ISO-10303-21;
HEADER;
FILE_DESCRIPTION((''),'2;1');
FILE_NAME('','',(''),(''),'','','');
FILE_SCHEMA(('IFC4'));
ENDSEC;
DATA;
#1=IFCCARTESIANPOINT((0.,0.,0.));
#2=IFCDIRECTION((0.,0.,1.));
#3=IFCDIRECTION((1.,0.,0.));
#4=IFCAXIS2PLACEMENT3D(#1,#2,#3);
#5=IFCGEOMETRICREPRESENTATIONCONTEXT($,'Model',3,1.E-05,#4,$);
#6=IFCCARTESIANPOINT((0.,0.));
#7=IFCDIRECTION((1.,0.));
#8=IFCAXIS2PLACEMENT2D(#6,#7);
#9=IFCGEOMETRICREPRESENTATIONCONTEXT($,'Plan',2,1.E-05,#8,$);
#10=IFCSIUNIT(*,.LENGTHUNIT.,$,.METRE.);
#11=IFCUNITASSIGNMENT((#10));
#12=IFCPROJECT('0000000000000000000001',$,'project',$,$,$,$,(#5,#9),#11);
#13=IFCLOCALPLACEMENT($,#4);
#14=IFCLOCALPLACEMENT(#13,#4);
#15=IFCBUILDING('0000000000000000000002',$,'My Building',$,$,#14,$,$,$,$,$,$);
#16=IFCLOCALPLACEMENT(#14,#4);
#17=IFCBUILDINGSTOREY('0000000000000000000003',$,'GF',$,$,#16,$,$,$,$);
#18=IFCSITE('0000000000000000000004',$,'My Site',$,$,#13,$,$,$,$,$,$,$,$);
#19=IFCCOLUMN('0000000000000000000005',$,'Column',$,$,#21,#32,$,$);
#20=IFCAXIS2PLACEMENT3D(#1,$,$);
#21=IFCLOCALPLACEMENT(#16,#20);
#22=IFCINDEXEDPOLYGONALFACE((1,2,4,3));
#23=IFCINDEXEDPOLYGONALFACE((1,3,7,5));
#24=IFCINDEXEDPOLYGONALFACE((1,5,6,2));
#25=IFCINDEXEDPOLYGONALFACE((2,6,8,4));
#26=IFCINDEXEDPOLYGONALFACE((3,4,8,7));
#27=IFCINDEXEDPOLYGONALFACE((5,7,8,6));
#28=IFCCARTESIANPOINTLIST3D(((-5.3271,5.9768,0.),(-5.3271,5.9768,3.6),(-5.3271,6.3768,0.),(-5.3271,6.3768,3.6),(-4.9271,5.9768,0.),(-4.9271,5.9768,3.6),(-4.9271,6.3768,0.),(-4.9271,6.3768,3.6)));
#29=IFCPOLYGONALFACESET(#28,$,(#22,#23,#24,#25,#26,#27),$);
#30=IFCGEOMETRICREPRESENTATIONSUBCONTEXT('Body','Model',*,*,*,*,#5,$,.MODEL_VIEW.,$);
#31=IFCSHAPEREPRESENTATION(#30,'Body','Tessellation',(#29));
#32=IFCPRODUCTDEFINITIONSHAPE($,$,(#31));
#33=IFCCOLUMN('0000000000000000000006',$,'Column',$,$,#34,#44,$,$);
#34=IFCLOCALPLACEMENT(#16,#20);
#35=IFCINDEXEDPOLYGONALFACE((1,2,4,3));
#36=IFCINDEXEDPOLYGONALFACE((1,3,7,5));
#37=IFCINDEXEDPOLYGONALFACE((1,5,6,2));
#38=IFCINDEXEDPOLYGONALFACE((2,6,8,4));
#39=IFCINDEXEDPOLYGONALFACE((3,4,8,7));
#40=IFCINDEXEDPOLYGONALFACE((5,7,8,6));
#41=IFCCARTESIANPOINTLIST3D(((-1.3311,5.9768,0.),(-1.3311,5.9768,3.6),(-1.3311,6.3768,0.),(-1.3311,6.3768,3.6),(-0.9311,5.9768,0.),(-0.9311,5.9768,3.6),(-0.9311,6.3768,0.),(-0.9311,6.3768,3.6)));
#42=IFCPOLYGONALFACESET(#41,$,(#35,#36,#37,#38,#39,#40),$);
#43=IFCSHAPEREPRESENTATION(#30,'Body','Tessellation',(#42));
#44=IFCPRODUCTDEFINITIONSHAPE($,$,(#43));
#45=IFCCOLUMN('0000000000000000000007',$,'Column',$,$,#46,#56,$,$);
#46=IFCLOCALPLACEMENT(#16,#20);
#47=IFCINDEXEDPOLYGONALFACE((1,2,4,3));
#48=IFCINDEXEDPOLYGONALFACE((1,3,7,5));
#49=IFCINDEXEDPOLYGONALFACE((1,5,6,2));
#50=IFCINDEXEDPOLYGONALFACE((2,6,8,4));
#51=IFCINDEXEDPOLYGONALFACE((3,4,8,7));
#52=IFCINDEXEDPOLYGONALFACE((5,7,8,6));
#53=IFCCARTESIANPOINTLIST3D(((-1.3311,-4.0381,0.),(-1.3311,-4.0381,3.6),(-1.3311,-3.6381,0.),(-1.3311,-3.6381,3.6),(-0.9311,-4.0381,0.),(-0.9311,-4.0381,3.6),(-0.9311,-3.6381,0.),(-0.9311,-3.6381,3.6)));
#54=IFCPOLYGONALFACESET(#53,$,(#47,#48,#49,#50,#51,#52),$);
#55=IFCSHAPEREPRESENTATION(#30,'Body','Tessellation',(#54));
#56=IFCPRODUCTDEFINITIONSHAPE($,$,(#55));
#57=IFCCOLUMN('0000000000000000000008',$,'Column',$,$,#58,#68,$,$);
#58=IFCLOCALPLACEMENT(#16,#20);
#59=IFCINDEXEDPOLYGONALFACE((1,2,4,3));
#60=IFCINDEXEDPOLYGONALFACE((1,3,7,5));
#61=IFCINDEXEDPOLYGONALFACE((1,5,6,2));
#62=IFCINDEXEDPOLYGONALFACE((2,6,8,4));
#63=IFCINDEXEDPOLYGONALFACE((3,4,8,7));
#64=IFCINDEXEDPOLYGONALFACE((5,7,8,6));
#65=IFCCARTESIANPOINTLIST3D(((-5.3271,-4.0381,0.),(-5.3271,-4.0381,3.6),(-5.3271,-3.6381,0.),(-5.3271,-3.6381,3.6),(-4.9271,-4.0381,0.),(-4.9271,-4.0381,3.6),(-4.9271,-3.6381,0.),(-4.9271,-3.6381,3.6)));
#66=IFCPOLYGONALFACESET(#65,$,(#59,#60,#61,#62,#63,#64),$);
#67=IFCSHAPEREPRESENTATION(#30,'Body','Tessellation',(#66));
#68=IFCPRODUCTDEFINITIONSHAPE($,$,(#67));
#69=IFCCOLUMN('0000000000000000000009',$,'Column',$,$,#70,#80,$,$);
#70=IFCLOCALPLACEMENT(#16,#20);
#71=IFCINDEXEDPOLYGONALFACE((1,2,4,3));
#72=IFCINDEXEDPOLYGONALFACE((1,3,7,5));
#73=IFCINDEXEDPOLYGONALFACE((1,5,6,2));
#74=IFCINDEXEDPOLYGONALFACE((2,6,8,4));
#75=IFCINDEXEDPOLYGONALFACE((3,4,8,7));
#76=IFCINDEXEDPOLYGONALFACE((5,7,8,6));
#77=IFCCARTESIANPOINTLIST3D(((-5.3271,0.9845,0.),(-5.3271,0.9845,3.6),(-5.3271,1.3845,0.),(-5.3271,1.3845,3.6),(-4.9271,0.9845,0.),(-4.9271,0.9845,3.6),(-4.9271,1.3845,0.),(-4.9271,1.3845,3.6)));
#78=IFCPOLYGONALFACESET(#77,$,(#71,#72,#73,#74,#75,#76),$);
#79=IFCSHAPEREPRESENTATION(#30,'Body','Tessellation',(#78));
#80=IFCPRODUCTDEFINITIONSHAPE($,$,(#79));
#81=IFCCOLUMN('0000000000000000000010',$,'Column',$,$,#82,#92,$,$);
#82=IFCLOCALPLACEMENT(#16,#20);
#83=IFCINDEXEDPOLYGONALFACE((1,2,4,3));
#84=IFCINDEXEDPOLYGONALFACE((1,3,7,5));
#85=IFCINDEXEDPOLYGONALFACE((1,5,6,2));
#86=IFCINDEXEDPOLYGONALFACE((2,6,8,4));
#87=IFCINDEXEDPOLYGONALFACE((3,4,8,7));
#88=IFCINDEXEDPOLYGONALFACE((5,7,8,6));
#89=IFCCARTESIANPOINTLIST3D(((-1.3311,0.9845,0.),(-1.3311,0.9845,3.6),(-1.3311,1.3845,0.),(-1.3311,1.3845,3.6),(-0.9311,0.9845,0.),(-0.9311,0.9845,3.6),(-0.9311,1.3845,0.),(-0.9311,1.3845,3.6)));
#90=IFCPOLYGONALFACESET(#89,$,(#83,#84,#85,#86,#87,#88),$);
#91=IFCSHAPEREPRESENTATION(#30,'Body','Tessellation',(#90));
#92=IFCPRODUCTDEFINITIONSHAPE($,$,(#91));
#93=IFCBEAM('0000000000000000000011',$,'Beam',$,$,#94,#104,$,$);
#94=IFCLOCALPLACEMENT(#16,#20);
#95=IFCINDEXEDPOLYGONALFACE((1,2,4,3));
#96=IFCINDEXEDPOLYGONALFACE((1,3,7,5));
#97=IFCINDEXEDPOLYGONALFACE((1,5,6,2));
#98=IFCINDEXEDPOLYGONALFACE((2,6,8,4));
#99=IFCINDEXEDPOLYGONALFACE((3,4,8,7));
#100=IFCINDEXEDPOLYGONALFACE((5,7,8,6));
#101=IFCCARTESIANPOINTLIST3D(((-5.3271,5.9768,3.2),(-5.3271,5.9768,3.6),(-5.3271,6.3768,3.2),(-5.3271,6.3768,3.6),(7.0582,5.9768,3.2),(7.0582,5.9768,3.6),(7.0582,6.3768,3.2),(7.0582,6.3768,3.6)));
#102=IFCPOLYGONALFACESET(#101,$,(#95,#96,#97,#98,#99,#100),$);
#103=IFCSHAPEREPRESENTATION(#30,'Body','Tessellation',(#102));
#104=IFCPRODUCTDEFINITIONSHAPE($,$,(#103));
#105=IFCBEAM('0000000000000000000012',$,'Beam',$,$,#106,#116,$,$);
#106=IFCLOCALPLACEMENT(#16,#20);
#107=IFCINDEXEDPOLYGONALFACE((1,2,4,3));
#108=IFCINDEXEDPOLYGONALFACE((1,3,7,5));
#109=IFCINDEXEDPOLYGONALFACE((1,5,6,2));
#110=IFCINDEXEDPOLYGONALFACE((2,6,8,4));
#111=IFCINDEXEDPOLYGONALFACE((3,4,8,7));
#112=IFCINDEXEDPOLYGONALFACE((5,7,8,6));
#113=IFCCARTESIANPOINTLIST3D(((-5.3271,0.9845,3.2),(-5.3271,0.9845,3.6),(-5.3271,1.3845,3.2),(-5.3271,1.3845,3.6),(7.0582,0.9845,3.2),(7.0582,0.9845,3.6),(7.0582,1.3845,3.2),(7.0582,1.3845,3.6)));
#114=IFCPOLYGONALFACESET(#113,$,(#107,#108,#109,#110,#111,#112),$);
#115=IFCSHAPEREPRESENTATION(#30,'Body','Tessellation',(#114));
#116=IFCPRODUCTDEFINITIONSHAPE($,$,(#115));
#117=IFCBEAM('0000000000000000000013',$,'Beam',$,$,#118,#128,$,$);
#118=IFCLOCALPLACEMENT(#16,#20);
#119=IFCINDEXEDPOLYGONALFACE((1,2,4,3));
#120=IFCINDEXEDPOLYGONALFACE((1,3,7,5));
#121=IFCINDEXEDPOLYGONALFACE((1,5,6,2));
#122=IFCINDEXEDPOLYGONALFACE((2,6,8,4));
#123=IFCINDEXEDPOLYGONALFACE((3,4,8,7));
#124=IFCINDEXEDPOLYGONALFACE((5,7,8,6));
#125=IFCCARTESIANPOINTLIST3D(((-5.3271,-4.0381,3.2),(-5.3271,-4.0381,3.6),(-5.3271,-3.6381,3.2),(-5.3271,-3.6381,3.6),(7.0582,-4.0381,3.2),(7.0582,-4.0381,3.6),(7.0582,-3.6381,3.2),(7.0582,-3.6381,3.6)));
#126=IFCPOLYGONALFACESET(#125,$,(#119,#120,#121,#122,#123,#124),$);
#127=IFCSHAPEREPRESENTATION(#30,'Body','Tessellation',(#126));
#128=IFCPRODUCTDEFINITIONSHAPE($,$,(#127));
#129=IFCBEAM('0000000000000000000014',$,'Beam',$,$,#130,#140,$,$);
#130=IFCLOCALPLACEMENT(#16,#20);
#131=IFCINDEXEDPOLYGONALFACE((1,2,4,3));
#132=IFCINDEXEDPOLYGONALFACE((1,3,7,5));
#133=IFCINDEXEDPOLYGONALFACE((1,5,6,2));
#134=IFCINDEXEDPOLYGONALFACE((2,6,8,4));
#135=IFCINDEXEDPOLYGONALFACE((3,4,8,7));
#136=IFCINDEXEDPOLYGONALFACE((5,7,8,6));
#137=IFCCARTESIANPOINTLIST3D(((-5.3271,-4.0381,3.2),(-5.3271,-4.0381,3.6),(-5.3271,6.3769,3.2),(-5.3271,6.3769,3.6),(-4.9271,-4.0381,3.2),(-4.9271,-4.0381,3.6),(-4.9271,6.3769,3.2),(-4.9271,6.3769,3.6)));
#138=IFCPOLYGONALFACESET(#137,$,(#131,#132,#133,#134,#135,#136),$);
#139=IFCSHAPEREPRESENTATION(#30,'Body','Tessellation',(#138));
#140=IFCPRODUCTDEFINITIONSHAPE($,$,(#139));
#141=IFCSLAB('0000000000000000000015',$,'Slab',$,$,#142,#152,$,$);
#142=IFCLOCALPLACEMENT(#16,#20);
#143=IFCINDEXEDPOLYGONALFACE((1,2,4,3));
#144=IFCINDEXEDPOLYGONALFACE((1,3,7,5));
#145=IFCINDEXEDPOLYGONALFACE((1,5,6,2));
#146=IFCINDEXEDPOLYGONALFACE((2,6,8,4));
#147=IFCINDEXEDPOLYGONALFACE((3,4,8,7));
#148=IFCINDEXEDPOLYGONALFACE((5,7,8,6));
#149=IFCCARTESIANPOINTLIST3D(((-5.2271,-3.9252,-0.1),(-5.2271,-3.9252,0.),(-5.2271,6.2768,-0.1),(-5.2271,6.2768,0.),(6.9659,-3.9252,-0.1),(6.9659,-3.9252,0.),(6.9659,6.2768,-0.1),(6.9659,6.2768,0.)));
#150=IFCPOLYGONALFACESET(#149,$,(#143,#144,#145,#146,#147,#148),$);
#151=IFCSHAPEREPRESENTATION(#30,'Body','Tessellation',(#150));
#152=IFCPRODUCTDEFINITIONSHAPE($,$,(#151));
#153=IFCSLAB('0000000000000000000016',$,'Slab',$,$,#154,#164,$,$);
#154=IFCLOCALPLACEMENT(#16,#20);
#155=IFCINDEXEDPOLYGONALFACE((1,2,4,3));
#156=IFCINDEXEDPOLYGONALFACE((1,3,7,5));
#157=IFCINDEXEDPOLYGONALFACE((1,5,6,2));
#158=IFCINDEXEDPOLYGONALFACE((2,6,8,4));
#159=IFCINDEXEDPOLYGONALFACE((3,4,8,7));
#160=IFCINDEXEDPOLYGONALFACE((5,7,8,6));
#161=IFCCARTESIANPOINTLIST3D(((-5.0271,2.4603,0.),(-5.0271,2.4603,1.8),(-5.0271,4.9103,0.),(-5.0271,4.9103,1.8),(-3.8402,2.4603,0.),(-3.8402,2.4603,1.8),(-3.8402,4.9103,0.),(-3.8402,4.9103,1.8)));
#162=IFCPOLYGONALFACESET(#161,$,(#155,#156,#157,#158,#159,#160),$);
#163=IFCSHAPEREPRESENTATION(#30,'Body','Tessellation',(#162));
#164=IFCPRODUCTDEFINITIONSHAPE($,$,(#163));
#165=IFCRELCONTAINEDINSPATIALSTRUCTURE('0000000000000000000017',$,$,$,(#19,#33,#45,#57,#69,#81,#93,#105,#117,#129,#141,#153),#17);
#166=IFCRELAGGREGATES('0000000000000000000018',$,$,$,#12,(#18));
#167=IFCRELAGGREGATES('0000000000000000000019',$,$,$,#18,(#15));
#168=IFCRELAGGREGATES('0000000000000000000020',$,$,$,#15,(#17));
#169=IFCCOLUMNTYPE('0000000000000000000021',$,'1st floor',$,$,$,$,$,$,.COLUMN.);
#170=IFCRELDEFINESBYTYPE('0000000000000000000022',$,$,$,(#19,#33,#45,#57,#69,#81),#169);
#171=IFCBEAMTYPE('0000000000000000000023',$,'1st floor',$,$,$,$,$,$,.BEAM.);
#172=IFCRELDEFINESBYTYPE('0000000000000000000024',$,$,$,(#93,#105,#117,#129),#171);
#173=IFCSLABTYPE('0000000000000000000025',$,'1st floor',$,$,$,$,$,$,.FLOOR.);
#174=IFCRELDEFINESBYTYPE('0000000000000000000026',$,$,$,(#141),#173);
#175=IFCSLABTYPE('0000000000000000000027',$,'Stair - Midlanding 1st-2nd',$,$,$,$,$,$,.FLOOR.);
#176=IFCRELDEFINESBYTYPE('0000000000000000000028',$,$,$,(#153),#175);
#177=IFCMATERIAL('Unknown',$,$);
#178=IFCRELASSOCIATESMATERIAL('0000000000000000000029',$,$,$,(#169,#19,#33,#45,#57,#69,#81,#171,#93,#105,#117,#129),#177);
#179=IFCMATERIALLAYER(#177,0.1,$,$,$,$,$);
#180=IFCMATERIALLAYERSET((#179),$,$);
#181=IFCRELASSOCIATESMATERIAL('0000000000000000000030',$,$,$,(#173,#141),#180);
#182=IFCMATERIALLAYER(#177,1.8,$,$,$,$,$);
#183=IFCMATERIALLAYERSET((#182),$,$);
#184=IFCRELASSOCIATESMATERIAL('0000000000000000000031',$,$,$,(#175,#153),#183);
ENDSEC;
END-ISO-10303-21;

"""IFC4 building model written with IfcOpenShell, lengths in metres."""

from ifc_helpers import new_model, si_unit, frame, origin_with_axes, origin_2d_with_axis, place, context, subcontext, project, spatial, indexed_curve, rectangle, outline, extrude, material, layer, layer_set, layer_usage, material_profile, profile_set, profile_usage, type_object, element, save


model = new_model("IFC4")

# Units and contexts
model_context = context("Model", 3, precision=1e-05, world=origin_with_axes())
plan_context = context("Plan", 2, precision=1e-05, world=origin_2d_with_axis())
body_context_1 = subcontext(model_context, "Body", "Model", "MODEL_VIEW")
ifc_project = project(units=[si_unit("LENGTHUNIT", "METRE")], contexts=[model_context, plan_context])

# Site, building, storey
site_placement = place(None, origin_with_axes())
site = spatial("IfcSite", under=ifc_project, at=site_placement, Name="My Site")
building_placement = place(site_placement, origin_with_axes())
building = spatial("IfcBuilding", under=site, at=building_placement, Name="My Building")
storey_placement = place(building_placement, origin_with_axes())
storey = spatial("IfcBuildingStorey", under=building, at=storey_placement, Name="GF")

# Columns
ifc_material = material(Name="Unknown")
ifc_material_profile_1 = material_profile(ifc_material, rectangle(XDim=0.4, YDim=0.4))
ifc_profile_set_1 = profile_set([ifc_material_profile_1])
ifc_profile_usage_1 = profile_usage(ifc_profile_set_1, cardinal=5)
column_type = type_object("IfcColumnType", Name="1st floor", PredefinedType="COLUMN", material=ifc_profile_set_1)
column_1_placement = place(storey_placement, frame((-5.1271, 6.1768, 0.0), z_axis=(0.0, 0.0, 1.0), x_axis=(1.0, 0.0, 0.0)))
element("IfcColumn", 1, at=column_1_placement, inside=storey, type_object=column_type, material=ifc_profile_usage_1, Name="Column", context=body_context_1, shape_type="SweptSolid", body=[
    extrude(rectangle(XDim=0.4, YDim=0.4), origin_with_axes(), (0.0, 0.0, 1.0), 3.6),
])
ifc_profile_usage_2 = profile_usage(ifc_profile_set_1, cardinal=5)
column_2_placement = place(storey_placement, frame((-1.1311, 6.1768, 0.0), z_axis=(0.0, 0.0, 1.0), x_axis=(1.0, 0.0, 0.0)))
element("IfcColumn", 2, at=column_2_placement, inside=storey, type_object=column_type, material=ifc_profile_usage_2, Name="Column", context=body_context_1, shape_type="SweptSolid", body=[
    extrude(rectangle(XDim=0.4, YDim=0.4), origin_with_axes(), (0.0, 0.0, 1.0), 3.6),
])
ifc_profile_usage_3 = profile_usage(ifc_profile_set_1, cardinal=5)
column_3_placement = place(storey_placement, frame((-1.1311, -3.8381, 0.0), z_axis=(0.0, 0.0, 1.0), x_axis=(1.0, 0.0, 0.0)))
element("IfcColumn", 3, at=column_3_placement, inside=storey, type_object=column_type, material=ifc_profile_usage_3, Name="Column", context=body_context_1, shape_type="SweptSolid", body=[
    extrude(rectangle(XDim=0.4, YDim=0.4), origin_with_axes(), (0.0, 0.0, 1.0), 3.6),
])
ifc_profile_usage_4 = profile_usage(ifc_profile_set_1, cardinal=5)
column_4_placement = place(storey_placement, frame((-5.1271, -3.8381, 0.0), z_axis=(0.0, 0.0, 1.0), x_axis=(1.0, 0.0, 0.0)))
element("IfcColumn", 4, at=column_4_placement, inside=storey, type_object=column_type, material=ifc_profile_usage_4, Name="Column", context=body_context_1, shape_type="SweptSolid", body=[
    extrude(rectangle(XDim=0.4, YDim=0.4), origin_with_axes(), (0.0, 0.0, 1.0), 3.6),
])
ifc_profile_usage_5 = profile_usage(ifc_profile_set_1, cardinal=5)
column_5_placement = place(storey_placement, frame((-5.1271, 1.1845, 0.0), z_axis=(0.0, 0.0, 1.0), x_axis=(1.0, 0.0, 0.0)))
element("IfcColumn", 5, at=column_5_placement, inside=storey, type_object=column_type, material=ifc_profile_usage_5, Name="Column", context=body_context_1, shape_type="SweptSolid", body=[
    extrude(rectangle(XDim=0.4, YDim=0.4), origin_with_axes(), (0.0, 0.0, 1.0), 3.6),
])
ifc_profile_usage_6 = profile_usage(ifc_profile_set_1, cardinal=5)
column_6_placement = place(storey_placement, frame((-1.1311, 1.1845, 0.0), z_axis=(0.0, 0.0, 1.0), x_axis=(1.0, 0.0, 0.0)))
element("IfcColumn", 6, at=column_6_placement, inside=storey, type_object=column_type, material=ifc_profile_usage_6, Name="Column", context=body_context_1, shape_type="SweptSolid", body=[
    extrude(rectangle(XDim=0.4, YDim=0.4), origin_with_axes(), (0.0, 0.0, 1.0), 3.6),
])

# Beams
ifc_material_profile_2 = material_profile(ifc_material, rectangle(XDim=0.4, YDim=0.4))
ifc_profile_set_2 = profile_set([ifc_material_profile_2])
ifc_profile_usage_7 = profile_usage(ifc_profile_set_2, cardinal=5)
beam_type = type_object("IfcBeamType", Name="1st floor", PredefinedType="BEAM", material=ifc_profile_set_2)
beam_1_placement = place(storey_placement, frame((-5.3271, 6.1768, 3.4), z_axis=(1.0, 0.0, 0.0), x_axis=(0.0, 1.0, 0.0)))
element("IfcBeam", 7, at=beam_1_placement, inside=storey, type_object=beam_type, material=ifc_profile_usage_7, Name="Beam", context=body_context_1, shape_type="SweptSolid", body=[
    extrude(rectangle(XDim=0.4, YDim=0.4), origin_with_axes(), (0.0, 0.0, 1.0), 12.3854),
])
ifc_profile_usage_8 = profile_usage(ifc_profile_set_2, cardinal=5)
beam_2_placement = place(storey_placement, frame((-5.3271, 1.1845, 3.4), z_axis=(1.0, 0.0, 0.0), x_axis=(0.0, 1.0, 0.0)))
element("IfcBeam", 8, at=beam_2_placement, inside=storey, type_object=beam_type, material=ifc_profile_usage_8, Name="Beam", context=body_context_1, shape_type="SweptSolid", body=[
    extrude(rectangle(XDim=0.4, YDim=0.4), origin_with_axes(), (0.0, 0.0, 1.0), 12.3854),
])
ifc_profile_usage_9 = profile_usage(ifc_profile_set_2, cardinal=5)
beam_3_placement = place(storey_placement, frame((-5.3271, -3.8381, 3.4), z_axis=(1.0, 0.0, 0.0), x_axis=(0.0, 1.0, 0.0)))
element("IfcBeam", 9, at=beam_3_placement, inside=storey, type_object=beam_type, material=ifc_profile_usage_9, Name="Beam", context=body_context_1, shape_type="SweptSolid", body=[
    extrude(rectangle(XDim=0.4, YDim=0.4), origin_with_axes(), (0.0, 0.0, 1.0), 12.3854),
])
ifc_profile_usage_10 = profile_usage(ifc_profile_set_2, cardinal=5)
beam_4_placement = place(storey_placement, frame((-5.1271, 6.3769, 3.4), z_axis=(0.0, -1.0, 0.0), x_axis=(1.0, 0.0, 0.0)))
element("IfcBeam", 10, at=beam_4_placement, inside=storey, type_object=beam_type, material=ifc_profile_usage_10, Name="Beam", context=body_context_1, shape_type="SweptSolid", body=[
    extrude(rectangle(XDim=0.4, YDim=0.4), origin_with_axes(), (0.0, 0.0, 1.0), 10.415),
])

# Slabs
ifc_layer_1 = layer(ifc_material, 0.1)
ifc_layer_set_1 = layer_set([ifc_layer_1])
ifc_layer_usage_1 = layer_usage(ifc_layer_set_1, "AXIS3", "POSITIVE", -0.1)
slab_type_1 = type_object("IfcSlabType", Name="1st floor", PredefinedType="FLOOR", material=ifc_layer_set_1)
slab_1_placement = place(storey_placement, frame((-5.2271, 6.2768, 0.0), z_axis=(0.0, 0.0, 1.0), x_axis=(1.0, 0.0, 0.0)))
element("IfcSlab", 11, at=slab_1_placement, inside=storey, type_object=slab_type_1, material=ifc_layer_usage_1, Name="Slab", context=body_context_1, shape_type="SweptSolid", body=[
    extrude(outline(indexed_curve([(0.0, 0.0), (0.0, -10.202), (12.193, -10.202), (12.193, 0.0), (0.0, 0.0)])), frame((0.0, 0.0, -0.1), z_axis=(0.0, 0.0, 1.0), x_axis=(1.0, 0.0, 0.0)), (0.0, 0.0, 1.0), 0.1),
])
ifc_layer_2 = layer(ifc_material, 1.8)
ifc_layer_set_2 = layer_set([ifc_layer_2])
slab_type_2 = type_object("IfcSlabType", Name="Stair - Midlanding 1st-2nd", PredefinedType="FLOOR", material=ifc_layer_set_2)
ifc_layer_usage_2 = layer_usage(ifc_layer_set_2, "AXIS3", "POSITIVE", -1.8)
slab_2_placement = place(storey_placement, frame((-3.8402, 4.9103, 1.8), z_axis=(0.0, 0.0, 1.0), x_axis=(1.0, 0.0, 0.0)))
element("IfcSlab", 12, at=slab_2_placement, inside=storey, type_object=slab_type_2, material=ifc_layer_usage_2, Name="Slab", context=body_context_1, shape_type="SweptSolid", body=[
    extrude(outline(indexed_curve([(0.0, 0.0), (0.0, -2.45), (-1.1869, -2.45), (-1.1869, 0.0), (0.0, 0.0)])), frame((0.0, 0.0, -1.8), z_axis=(0.0, 0.0, 1.0), x_axis=(1.0, 0.0, 0.0)), (0.0, 0.0, 1.0), 1.8),
])

save(model, "model.ifc")
